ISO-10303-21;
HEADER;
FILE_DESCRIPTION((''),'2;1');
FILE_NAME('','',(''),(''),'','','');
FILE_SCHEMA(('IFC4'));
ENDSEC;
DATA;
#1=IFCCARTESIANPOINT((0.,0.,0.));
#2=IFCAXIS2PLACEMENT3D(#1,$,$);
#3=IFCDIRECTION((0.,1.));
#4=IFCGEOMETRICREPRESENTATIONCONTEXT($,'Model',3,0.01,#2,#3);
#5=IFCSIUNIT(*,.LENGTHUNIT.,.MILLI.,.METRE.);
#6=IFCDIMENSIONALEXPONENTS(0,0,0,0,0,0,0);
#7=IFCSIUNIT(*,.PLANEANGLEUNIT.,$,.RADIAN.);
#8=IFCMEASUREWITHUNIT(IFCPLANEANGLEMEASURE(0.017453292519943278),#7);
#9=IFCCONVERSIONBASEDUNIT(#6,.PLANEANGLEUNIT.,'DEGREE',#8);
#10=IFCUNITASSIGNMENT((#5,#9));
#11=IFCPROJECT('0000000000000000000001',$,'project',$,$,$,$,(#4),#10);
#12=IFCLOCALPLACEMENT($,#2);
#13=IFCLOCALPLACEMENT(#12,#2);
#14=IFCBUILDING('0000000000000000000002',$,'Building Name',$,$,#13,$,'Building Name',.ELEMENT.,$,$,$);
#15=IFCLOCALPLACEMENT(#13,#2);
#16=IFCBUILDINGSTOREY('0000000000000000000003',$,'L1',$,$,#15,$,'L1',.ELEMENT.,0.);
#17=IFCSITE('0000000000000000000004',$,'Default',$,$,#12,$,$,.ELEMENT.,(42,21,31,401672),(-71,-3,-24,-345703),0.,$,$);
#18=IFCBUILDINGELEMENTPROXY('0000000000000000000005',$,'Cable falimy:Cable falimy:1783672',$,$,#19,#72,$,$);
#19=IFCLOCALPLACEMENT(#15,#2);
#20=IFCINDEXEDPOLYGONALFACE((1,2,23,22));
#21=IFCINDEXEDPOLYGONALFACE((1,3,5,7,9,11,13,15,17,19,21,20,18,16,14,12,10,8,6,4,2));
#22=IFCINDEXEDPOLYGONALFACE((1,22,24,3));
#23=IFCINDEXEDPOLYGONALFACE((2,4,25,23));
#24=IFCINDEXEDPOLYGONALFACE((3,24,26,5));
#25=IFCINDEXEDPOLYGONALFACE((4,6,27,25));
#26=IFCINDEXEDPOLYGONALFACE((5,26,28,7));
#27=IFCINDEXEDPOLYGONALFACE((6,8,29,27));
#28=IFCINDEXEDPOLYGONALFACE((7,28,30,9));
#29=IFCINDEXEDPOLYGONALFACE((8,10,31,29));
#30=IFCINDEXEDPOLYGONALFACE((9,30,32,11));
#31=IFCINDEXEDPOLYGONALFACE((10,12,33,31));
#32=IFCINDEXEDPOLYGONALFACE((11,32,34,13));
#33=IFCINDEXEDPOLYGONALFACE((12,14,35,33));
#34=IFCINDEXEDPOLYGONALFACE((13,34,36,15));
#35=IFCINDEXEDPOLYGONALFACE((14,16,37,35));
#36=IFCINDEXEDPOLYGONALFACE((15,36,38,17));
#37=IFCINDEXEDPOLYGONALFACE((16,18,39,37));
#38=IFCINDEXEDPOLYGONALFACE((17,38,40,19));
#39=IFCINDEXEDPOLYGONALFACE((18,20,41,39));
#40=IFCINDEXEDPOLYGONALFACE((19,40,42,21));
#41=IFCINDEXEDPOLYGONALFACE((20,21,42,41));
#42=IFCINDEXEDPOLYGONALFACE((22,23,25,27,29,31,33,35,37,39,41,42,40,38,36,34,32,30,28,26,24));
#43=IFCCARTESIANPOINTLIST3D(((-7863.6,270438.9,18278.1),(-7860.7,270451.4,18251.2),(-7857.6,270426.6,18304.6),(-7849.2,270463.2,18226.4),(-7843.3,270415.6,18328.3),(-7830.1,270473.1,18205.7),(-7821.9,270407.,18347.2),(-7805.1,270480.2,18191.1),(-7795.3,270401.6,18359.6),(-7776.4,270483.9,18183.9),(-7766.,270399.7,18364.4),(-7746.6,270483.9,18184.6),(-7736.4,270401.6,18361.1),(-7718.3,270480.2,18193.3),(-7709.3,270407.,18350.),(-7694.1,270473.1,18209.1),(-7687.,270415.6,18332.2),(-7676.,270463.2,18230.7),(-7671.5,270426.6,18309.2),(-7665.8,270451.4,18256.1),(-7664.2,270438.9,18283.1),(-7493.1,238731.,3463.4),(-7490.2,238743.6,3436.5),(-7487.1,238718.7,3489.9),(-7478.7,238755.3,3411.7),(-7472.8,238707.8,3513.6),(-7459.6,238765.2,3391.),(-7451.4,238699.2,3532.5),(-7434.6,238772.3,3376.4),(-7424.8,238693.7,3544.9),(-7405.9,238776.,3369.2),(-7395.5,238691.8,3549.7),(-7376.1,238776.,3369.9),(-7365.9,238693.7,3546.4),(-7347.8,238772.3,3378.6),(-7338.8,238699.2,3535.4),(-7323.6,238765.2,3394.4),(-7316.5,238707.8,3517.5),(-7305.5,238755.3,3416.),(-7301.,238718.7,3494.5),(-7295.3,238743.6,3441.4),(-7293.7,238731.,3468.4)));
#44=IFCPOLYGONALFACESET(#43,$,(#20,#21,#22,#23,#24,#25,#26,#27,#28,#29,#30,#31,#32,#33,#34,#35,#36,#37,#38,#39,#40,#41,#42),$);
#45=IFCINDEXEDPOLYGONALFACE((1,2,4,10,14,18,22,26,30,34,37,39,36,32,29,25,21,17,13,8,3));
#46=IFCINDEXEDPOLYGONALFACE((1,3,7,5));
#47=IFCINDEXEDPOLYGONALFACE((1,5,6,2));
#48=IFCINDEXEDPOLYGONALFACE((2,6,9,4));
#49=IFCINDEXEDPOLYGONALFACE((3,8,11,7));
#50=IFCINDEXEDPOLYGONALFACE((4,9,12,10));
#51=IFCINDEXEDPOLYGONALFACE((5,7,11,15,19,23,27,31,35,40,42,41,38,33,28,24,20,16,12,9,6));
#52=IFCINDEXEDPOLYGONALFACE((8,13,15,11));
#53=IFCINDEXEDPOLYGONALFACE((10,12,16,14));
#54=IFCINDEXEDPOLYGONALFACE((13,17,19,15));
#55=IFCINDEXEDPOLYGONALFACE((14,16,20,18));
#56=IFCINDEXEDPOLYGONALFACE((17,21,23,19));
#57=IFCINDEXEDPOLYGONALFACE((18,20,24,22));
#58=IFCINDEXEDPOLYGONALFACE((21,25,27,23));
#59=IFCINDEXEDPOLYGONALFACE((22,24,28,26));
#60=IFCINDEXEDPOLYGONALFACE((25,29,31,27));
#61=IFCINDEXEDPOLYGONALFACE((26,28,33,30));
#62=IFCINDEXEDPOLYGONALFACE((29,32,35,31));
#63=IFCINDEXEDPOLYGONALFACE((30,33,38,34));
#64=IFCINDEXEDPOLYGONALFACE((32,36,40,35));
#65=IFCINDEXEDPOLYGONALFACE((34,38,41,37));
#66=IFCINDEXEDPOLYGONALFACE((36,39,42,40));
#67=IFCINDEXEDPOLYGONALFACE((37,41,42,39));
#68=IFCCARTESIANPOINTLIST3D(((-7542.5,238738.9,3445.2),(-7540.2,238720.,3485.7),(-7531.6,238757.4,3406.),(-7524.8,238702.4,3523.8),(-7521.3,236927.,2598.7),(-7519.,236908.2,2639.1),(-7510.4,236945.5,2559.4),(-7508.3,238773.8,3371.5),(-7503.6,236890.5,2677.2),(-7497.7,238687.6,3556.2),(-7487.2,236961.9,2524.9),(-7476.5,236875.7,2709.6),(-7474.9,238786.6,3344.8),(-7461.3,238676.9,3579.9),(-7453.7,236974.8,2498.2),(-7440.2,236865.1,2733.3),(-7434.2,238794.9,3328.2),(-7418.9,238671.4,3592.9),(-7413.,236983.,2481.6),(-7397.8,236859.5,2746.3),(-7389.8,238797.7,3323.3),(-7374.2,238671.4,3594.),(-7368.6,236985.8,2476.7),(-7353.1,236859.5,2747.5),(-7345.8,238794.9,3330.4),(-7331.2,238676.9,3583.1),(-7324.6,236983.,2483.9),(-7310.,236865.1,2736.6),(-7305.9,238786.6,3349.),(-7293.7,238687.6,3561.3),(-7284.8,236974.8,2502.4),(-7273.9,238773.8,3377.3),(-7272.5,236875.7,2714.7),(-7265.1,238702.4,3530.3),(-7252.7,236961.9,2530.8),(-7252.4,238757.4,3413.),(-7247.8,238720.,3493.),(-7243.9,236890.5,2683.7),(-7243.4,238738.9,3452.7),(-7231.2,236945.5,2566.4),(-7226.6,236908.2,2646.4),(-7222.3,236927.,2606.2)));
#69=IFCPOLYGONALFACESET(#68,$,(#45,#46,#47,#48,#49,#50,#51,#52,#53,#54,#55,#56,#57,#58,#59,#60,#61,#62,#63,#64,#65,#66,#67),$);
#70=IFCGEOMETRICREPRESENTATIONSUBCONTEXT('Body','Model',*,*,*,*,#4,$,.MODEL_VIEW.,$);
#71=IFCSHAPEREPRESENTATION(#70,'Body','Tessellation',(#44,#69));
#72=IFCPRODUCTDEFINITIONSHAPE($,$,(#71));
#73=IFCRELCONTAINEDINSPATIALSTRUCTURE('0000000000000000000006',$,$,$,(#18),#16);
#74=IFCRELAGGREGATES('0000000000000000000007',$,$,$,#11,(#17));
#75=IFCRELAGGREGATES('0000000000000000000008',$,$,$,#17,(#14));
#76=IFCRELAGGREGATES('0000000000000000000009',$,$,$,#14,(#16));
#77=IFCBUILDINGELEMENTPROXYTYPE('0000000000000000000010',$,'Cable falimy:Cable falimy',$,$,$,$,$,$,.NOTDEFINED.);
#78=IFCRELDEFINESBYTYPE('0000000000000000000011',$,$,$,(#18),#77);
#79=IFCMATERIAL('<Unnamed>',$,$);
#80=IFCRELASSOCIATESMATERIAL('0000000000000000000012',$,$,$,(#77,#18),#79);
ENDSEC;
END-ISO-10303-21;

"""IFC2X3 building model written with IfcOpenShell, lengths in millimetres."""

from ifc_helpers import new_model, entity, si_unit, converted_unit, direction, frame, frame_2d, origin, place, context, subcontext, project, spatial, circle, extrude, source, transform, mapped, material, type_object, type_shapes, element, save


model = new_model("IFC2X3")

# Units and contexts
model_context = context("Model", 3, precision=0.01, world=origin(), true_north=direction((0.0, 1.0)))
body_context = subcontext(model_context, "Body", "Model", "MODEL_VIEW")
ifc_project = project(units=[si_unit("LENGTHUNIT", "METRE", prefix="MILLI"), converted_unit("PLANEANGLEUNIT", "DEGREE", entity("IfcPlaneAngleMeasure", 0.017453292519943278), si_unit("PLANEANGLEUNIT", "RADIAN"), dimensions=[0, 0, 0, 0, 0, 0, 0])], contexts=[model_context])

# Site, building, storey
site_placement = place(None, origin())
site = spatial("IfcSite", under=ifc_project, at=site_placement, Name="Default", CompositionType="ELEMENT", RefLatitude=(42, 21, 31, 401672), RefLongitude=(-71, -3, -24, -345703), RefElevation=0.0)
building_placement = place(site_placement, origin())
building = spatial("IfcBuilding", under=site, at=building_placement, Name="Building Name", LongName="Building Name", CompositionType="ELEMENT")
storey_placement = place(building_placement, origin())
storey = spatial("IfcBuildingStorey", under=building, at=storey_placement, Name="L1", LongName="L1", CompositionType="ELEMENT", Elevation=0.0)

# Shared definitions
ifc_material = material(Name="<Unnamed>")

# Building element proxy
building_element_proxy_type_1 = type_object("IfcBuildingElementProxyType", Name="Cable falimy:Cable falimy", PredefinedType="NOTDEFINED", material=ifc_material)
shared_shape_1 = source(origin(), body_context, "Body", "SweptSolid", [
    extrude(circle(Radius=100.0, at=frame_2d((0.0, 0.0), x_axis=(1.0, 0.0))), frame((0.0, 0.0, 0.0), z_axis=(0.905939, 0.0, 0.423409), x_axis=(-0.423409, 0.0, 0.905939)), (0.0, 0.0, 1.0), 35000.0),
    extrude(circle(Radius=150.0, at=frame_2d((0.0, 0.0), x_axis=(1.0, 0.0))), frame((-1811.9, 0.0, -846.8), z_axis=(0.905939, 0.0, 0.423409), x_axis=(0.423409, 0.0, -0.905939)), (0.0, 0.0, 1.0), 2000.0),
])
type_shapes(building_element_proxy_type_1, [shared_shape_1])
proxy_1_placement = place(storey_placement, frame((-7393.2, 238734.2, 3459.1), z_axis=(-0.025001, 0.0, 0.999687), x_axis=(0.0, 1.0, 0.0)))
element("IfcBuildingElementProxy", 1, at=proxy_1_placement, inside=storey, type_object=building_element_proxy_type_1, material=ifc_material, Name="Cable falimy:Cable falimy:1783672", context=body_context, shape_type="MappedRepresentation", body=[
    mapped(shared_shape_1, transform((0.0, 0.0, 0.0), scale=1.0)),
])

save(model, "model.ifc")
